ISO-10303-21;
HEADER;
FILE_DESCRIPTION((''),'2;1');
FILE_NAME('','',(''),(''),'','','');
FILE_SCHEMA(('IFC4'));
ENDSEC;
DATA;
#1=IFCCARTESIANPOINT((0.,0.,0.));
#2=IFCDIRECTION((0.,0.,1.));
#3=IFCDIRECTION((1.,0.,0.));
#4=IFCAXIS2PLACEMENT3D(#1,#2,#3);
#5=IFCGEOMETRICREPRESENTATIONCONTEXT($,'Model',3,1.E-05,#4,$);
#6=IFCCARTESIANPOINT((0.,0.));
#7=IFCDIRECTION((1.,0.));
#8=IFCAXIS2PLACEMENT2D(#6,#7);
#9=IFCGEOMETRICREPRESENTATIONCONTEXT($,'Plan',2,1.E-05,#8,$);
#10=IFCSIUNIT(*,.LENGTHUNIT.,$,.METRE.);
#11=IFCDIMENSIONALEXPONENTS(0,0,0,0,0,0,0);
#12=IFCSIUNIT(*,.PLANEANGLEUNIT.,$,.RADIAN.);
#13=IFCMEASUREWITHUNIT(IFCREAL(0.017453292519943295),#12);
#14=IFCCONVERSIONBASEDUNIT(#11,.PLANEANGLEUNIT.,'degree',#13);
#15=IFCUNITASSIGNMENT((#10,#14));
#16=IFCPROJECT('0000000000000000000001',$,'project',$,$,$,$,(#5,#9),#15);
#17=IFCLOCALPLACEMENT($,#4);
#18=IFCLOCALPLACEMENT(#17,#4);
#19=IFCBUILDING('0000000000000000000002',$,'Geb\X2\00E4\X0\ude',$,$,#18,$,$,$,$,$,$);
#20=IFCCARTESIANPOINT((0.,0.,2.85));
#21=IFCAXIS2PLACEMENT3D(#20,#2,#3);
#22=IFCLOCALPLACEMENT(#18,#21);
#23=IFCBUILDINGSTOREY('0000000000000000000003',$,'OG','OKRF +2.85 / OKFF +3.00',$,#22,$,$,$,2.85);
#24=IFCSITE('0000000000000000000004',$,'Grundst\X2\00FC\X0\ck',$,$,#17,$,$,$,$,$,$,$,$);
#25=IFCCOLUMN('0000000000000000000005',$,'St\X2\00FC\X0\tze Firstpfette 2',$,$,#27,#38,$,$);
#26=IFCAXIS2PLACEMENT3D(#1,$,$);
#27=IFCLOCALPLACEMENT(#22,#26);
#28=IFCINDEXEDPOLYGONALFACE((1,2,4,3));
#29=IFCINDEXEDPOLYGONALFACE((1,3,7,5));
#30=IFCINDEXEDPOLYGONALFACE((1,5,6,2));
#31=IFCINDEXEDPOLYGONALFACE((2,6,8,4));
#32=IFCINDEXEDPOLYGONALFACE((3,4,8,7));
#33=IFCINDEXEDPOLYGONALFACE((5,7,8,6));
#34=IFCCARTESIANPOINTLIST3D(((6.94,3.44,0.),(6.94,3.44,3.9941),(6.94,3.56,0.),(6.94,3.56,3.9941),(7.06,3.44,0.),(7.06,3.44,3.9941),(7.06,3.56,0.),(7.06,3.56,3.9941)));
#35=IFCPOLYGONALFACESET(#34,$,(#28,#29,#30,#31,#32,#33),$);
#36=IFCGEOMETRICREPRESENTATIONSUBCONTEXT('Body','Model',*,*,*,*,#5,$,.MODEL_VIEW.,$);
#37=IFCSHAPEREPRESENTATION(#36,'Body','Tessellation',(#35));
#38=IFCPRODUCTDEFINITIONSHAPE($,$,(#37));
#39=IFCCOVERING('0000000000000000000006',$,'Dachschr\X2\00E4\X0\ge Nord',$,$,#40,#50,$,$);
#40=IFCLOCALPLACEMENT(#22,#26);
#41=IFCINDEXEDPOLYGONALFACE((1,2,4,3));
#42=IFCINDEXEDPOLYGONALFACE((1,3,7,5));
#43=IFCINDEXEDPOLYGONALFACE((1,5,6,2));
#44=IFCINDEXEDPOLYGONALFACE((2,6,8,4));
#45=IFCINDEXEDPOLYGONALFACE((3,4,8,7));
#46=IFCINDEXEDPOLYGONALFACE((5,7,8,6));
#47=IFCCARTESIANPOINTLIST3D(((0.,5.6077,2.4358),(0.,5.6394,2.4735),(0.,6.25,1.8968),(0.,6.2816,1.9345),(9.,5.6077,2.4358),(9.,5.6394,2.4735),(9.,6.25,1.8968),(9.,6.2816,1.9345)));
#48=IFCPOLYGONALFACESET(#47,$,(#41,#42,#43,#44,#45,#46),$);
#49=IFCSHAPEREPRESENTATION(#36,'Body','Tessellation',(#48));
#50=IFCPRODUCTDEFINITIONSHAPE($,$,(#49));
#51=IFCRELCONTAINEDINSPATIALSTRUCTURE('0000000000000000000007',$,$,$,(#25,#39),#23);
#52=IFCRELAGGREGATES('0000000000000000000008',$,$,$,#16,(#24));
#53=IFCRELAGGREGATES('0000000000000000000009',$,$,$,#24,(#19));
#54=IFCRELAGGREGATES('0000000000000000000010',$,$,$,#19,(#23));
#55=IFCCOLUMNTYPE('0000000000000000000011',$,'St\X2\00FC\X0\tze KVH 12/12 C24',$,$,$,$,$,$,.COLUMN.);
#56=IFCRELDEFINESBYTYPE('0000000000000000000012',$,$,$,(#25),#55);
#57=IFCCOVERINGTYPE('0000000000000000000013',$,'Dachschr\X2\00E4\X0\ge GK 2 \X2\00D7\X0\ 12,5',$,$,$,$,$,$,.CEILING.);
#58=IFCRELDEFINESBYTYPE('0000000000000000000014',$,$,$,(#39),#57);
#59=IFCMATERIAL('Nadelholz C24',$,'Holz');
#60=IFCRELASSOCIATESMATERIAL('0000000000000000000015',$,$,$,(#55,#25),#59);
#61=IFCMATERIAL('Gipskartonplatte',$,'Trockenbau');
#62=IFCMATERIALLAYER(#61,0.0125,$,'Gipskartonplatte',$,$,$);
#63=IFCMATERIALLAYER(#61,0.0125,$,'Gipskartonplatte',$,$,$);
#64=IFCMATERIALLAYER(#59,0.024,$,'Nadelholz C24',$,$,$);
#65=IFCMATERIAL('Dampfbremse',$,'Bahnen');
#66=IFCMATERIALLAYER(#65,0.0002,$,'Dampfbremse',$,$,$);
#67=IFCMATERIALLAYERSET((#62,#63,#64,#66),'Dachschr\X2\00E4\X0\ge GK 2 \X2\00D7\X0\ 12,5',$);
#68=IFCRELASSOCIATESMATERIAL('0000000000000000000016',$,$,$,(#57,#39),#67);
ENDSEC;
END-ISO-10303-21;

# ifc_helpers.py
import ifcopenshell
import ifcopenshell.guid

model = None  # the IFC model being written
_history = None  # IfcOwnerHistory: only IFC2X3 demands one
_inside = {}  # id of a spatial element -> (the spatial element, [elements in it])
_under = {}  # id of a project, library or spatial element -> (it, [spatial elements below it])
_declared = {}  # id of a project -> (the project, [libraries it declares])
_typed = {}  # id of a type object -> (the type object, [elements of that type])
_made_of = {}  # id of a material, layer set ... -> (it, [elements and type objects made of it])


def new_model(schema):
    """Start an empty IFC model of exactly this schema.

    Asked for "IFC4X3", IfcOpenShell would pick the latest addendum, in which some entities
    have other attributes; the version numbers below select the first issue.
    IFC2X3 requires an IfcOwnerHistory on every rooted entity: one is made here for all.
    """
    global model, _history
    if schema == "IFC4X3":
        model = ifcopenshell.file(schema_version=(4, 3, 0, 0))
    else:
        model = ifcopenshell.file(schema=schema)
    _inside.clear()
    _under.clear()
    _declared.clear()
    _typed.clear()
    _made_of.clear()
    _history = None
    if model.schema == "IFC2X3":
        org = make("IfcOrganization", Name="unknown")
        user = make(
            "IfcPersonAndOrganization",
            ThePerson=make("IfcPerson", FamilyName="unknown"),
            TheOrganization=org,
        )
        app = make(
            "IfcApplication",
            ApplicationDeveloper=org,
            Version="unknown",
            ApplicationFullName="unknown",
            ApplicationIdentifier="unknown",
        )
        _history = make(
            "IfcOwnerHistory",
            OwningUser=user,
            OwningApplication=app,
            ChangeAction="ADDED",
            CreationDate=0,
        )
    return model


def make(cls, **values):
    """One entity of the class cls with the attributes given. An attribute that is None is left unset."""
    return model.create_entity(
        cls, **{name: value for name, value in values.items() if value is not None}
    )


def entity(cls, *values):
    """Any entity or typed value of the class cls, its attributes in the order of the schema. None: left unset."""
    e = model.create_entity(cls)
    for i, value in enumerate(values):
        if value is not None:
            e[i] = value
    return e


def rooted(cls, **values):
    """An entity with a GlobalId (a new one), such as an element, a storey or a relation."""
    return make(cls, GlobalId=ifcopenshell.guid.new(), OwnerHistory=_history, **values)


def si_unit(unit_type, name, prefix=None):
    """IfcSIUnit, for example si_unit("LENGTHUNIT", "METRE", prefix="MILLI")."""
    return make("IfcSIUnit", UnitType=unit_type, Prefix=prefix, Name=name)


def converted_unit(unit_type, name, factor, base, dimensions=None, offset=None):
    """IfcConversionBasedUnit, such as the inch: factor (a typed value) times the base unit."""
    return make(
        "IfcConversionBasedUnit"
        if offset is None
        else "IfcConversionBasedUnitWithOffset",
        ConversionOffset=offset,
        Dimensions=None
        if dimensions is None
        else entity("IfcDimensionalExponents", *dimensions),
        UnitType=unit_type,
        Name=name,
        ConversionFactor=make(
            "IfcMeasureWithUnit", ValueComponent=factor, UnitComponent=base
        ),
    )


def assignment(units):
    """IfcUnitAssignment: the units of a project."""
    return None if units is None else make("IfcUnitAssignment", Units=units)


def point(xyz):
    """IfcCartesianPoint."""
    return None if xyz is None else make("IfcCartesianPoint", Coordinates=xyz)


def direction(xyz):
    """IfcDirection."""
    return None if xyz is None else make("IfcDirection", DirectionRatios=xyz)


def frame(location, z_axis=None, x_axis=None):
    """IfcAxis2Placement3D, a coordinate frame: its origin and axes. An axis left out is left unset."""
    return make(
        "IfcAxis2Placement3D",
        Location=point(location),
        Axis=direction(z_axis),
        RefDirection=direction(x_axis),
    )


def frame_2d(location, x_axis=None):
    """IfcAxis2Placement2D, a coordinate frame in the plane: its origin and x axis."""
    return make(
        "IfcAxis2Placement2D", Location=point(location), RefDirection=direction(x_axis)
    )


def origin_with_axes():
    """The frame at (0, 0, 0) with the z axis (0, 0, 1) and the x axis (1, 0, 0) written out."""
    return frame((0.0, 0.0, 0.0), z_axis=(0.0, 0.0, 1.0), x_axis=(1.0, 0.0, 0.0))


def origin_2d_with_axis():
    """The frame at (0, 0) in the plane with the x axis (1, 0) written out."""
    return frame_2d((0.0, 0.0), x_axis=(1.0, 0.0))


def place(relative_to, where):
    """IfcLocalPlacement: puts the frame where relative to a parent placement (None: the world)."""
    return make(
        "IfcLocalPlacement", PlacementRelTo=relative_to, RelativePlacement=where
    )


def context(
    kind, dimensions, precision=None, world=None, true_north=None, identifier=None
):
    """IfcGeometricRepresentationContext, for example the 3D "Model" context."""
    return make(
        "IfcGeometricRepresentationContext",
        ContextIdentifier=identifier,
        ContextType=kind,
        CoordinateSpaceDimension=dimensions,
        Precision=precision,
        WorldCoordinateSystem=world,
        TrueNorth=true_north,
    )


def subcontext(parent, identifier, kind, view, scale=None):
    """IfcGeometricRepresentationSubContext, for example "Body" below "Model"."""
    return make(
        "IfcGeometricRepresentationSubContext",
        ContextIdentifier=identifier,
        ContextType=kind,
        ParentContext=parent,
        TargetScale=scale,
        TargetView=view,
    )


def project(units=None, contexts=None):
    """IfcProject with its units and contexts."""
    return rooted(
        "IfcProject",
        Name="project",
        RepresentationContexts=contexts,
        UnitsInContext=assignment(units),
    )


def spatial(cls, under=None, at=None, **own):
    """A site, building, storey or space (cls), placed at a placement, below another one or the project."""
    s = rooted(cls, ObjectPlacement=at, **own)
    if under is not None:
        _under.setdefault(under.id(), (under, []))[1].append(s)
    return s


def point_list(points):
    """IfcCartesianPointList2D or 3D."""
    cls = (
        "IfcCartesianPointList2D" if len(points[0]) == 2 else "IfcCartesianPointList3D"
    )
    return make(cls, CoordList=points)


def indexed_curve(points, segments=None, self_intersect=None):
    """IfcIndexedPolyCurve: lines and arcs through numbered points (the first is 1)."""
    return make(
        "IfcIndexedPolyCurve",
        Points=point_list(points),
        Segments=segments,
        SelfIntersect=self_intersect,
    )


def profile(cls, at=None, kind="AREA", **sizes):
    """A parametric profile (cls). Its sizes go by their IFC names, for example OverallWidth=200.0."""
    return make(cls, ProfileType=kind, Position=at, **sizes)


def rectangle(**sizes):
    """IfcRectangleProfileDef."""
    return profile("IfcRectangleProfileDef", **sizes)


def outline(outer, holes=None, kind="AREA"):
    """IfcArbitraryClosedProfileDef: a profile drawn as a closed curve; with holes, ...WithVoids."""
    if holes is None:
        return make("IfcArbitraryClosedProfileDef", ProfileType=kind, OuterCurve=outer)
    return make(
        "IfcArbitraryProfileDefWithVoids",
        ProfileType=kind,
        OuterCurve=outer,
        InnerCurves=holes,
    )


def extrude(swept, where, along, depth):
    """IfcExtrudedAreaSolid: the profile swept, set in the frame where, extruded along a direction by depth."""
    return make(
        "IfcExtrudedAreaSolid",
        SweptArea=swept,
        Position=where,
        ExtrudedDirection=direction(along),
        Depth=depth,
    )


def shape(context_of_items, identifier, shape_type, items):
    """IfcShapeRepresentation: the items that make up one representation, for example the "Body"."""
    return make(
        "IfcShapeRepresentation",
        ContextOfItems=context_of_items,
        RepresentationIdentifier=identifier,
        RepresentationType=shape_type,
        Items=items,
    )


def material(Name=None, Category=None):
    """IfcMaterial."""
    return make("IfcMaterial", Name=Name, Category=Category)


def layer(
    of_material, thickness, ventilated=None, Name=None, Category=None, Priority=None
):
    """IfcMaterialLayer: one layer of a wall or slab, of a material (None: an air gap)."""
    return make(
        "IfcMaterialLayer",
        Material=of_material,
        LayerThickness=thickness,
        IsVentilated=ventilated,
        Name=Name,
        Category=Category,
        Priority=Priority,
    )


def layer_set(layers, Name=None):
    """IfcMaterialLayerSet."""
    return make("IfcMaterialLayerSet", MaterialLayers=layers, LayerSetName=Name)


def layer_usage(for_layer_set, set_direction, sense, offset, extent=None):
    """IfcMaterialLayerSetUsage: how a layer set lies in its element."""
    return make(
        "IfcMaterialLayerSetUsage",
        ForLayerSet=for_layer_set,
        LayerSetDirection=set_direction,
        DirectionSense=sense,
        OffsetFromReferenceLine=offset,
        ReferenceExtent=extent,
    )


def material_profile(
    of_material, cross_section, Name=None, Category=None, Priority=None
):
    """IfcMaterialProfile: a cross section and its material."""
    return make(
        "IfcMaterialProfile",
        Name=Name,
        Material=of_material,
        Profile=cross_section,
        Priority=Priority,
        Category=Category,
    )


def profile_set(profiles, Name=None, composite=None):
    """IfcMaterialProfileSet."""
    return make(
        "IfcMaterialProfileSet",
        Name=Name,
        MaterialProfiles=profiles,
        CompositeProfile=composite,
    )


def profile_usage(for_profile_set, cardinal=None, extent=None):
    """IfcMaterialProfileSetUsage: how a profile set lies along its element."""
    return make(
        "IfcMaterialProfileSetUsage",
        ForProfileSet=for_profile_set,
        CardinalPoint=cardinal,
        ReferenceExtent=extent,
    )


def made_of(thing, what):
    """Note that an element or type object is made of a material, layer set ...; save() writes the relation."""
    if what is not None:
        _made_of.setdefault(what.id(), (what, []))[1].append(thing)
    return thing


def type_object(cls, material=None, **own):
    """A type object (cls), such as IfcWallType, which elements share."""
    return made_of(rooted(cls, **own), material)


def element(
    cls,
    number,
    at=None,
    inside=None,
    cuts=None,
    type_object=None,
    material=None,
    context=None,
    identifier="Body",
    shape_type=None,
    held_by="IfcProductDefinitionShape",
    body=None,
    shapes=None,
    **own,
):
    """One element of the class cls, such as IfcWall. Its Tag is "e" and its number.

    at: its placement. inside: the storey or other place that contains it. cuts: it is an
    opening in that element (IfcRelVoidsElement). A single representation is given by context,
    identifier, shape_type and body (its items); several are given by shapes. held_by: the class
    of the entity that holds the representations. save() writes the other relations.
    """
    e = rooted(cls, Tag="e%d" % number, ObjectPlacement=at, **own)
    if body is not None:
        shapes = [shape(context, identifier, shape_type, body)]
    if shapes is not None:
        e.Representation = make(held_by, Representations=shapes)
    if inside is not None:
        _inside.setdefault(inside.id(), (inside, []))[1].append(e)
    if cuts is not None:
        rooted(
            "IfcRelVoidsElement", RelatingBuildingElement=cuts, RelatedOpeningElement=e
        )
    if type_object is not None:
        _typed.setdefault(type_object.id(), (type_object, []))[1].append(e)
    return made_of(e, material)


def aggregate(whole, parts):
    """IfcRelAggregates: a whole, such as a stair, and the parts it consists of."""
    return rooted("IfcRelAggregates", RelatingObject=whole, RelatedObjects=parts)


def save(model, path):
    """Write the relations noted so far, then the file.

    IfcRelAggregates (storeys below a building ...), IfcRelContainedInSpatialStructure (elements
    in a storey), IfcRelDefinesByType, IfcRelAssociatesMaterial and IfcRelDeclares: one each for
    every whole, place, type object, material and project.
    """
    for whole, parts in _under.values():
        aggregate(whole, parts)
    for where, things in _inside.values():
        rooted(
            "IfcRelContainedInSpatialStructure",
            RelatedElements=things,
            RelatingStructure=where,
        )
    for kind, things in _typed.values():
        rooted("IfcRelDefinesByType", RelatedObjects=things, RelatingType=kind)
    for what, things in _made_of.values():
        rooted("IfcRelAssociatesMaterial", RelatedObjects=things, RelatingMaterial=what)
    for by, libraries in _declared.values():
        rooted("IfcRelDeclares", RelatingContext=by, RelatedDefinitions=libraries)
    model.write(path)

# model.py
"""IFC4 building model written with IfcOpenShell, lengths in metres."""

from ifc_helpers import new_model, entity, si_unit, converted_unit, frame, origin_with_axes, origin_2d_with_axis, place, context, subcontext, project, spatial, indexed_curve, rectangle, outline, extrude, material, layer, layer_set, layer_usage, material_profile, profile_set, profile_usage, type_object, element, save


model = new_model("IFC4")

# Units and contexts
model_context = context("Model", 3, precision=1e-05, world=origin_with_axes())
plan_context = context("Plan", 2, precision=1e-05, world=origin_2d_with_axis())
body_context_1 = subcontext(model_context, "Body", "Model", "MODEL_VIEW")
ifc_project = project(units=[si_unit("LENGTHUNIT", "METRE"), converted_unit("PLANEANGLEUNIT", "degree", entity("IfcReal", 0.017453292519943295), si_unit("PLANEANGLEUNIT", "RADIAN"), dimensions=[0, 0, 0, 0, 0, 0, 0])], contexts=[model_context, plan_context])

# Site, building, storey
site_placement = place(None, origin_with_axes())
site = spatial("IfcSite", under=ifc_project, at=site_placement, Name="Grundstück")
building_placement = place(site_placement, origin_with_axes())
building = spatial("IfcBuilding", under=site, at=building_placement, Name="Gebäude")
storey_placement = place(building_placement, frame((0.0, 0.0, 2.85), z_axis=(0.0, 0.0, 1.0), x_axis=(1.0, 0.0, 0.0)))
storey = spatial("IfcBuildingStorey", under=building, at=storey_placement, Name="OG", Description="OKRF +2.85 / OKFF +3.00", Elevation=2.85)

# Column
ifc_material_1 = material(Name="Nadelholz C24", Category="Holz")
ifc_material_profile_1 = material_profile(ifc_material_1, rectangle(XDim=0.12, YDim=0.12))
ifc_profile_set_1 = profile_set([ifc_material_profile_1], Name="Stütze KVH 12/12 C24")
ifc_profile_usage_1 = profile_usage(ifc_profile_set_1)
column_type = type_object("IfcColumnType", Name="Stütze KVH 12/12 C24", PredefinedType="COLUMN", material=ifc_profile_set_1)
column_placement = place(storey_placement, frame((7.0, 3.5, 0.0), z_axis=(0.0, 0.0, 1.0), x_axis=(1.0, 0.0, 0.0)))
element("IfcColumn", 1, at=column_placement, inside=storey, type_object=column_type, material=ifc_profile_usage_1, Name="Stütze Firstpfette 2", context=body_context_1, shape_type="SweptSolid", body=[
    extrude(rectangle(XDim=0.12, YDim=0.12), origin_with_axes(), (0.0, 0.0, 1.0), 3.9941),
])

# Shared definitions
ifc_material_2 = material(Name="Gipskartonplatte", Category="Trockenbau")

# Covering
ifc_layer_1 = layer(ifc_material_2, 0.0125, Name="Gipskartonplatte")
ifc_layer_2 = layer(ifc_material_2, 0.0125, Name="Gipskartonplatte")
ifc_layer_3 = layer(ifc_material_1, 0.024, Name="Nadelholz C24")
ifc_material_3 = material(Name="Dampfbremse", Category="Bahnen")
ifc_layer_4 = layer(ifc_material_3, 0.0002, Name="Dampfbremse")
ifc_layer_set_1 = layer_set([ifc_layer_1, ifc_layer_2, ifc_layer_3, ifc_layer_4], Name="Dachschräge GK 2 × 12,5")
ifc_layer_usage_1 = layer_usage(ifc_layer_set_1, "AXIS3", "POSITIVE", 0.0)
covering_type_1 = type_object("IfcCoveringType", Name="Dachschräge GK 2 × 12,5", PredefinedType="CEILING", material=ifc_layer_set_1)
covering_1_placement = place(storey_placement, frame((9.0, 6.25, 1.8968), z_axis=(0.0, 0.642788, 0.766044), x_axis=(-1.0, 0.0, 0.0)))
element("IfcCovering", 2, at=covering_1_placement, inside=storey, type_object=covering_type_1, material=ifc_layer_usage_1, Name="Dachschräge Nord", context=body_context_1, shape_type="SweptSolid", body=[
    extrude(outline(indexed_curve([(0.0, 0.0), (9.0, 0.0), (9.0, 0.8384), (0.0, 0.8384)])), None, (0.0, 0.0, 1.0), 0.0492),
])

save(model, "model.ifc")
